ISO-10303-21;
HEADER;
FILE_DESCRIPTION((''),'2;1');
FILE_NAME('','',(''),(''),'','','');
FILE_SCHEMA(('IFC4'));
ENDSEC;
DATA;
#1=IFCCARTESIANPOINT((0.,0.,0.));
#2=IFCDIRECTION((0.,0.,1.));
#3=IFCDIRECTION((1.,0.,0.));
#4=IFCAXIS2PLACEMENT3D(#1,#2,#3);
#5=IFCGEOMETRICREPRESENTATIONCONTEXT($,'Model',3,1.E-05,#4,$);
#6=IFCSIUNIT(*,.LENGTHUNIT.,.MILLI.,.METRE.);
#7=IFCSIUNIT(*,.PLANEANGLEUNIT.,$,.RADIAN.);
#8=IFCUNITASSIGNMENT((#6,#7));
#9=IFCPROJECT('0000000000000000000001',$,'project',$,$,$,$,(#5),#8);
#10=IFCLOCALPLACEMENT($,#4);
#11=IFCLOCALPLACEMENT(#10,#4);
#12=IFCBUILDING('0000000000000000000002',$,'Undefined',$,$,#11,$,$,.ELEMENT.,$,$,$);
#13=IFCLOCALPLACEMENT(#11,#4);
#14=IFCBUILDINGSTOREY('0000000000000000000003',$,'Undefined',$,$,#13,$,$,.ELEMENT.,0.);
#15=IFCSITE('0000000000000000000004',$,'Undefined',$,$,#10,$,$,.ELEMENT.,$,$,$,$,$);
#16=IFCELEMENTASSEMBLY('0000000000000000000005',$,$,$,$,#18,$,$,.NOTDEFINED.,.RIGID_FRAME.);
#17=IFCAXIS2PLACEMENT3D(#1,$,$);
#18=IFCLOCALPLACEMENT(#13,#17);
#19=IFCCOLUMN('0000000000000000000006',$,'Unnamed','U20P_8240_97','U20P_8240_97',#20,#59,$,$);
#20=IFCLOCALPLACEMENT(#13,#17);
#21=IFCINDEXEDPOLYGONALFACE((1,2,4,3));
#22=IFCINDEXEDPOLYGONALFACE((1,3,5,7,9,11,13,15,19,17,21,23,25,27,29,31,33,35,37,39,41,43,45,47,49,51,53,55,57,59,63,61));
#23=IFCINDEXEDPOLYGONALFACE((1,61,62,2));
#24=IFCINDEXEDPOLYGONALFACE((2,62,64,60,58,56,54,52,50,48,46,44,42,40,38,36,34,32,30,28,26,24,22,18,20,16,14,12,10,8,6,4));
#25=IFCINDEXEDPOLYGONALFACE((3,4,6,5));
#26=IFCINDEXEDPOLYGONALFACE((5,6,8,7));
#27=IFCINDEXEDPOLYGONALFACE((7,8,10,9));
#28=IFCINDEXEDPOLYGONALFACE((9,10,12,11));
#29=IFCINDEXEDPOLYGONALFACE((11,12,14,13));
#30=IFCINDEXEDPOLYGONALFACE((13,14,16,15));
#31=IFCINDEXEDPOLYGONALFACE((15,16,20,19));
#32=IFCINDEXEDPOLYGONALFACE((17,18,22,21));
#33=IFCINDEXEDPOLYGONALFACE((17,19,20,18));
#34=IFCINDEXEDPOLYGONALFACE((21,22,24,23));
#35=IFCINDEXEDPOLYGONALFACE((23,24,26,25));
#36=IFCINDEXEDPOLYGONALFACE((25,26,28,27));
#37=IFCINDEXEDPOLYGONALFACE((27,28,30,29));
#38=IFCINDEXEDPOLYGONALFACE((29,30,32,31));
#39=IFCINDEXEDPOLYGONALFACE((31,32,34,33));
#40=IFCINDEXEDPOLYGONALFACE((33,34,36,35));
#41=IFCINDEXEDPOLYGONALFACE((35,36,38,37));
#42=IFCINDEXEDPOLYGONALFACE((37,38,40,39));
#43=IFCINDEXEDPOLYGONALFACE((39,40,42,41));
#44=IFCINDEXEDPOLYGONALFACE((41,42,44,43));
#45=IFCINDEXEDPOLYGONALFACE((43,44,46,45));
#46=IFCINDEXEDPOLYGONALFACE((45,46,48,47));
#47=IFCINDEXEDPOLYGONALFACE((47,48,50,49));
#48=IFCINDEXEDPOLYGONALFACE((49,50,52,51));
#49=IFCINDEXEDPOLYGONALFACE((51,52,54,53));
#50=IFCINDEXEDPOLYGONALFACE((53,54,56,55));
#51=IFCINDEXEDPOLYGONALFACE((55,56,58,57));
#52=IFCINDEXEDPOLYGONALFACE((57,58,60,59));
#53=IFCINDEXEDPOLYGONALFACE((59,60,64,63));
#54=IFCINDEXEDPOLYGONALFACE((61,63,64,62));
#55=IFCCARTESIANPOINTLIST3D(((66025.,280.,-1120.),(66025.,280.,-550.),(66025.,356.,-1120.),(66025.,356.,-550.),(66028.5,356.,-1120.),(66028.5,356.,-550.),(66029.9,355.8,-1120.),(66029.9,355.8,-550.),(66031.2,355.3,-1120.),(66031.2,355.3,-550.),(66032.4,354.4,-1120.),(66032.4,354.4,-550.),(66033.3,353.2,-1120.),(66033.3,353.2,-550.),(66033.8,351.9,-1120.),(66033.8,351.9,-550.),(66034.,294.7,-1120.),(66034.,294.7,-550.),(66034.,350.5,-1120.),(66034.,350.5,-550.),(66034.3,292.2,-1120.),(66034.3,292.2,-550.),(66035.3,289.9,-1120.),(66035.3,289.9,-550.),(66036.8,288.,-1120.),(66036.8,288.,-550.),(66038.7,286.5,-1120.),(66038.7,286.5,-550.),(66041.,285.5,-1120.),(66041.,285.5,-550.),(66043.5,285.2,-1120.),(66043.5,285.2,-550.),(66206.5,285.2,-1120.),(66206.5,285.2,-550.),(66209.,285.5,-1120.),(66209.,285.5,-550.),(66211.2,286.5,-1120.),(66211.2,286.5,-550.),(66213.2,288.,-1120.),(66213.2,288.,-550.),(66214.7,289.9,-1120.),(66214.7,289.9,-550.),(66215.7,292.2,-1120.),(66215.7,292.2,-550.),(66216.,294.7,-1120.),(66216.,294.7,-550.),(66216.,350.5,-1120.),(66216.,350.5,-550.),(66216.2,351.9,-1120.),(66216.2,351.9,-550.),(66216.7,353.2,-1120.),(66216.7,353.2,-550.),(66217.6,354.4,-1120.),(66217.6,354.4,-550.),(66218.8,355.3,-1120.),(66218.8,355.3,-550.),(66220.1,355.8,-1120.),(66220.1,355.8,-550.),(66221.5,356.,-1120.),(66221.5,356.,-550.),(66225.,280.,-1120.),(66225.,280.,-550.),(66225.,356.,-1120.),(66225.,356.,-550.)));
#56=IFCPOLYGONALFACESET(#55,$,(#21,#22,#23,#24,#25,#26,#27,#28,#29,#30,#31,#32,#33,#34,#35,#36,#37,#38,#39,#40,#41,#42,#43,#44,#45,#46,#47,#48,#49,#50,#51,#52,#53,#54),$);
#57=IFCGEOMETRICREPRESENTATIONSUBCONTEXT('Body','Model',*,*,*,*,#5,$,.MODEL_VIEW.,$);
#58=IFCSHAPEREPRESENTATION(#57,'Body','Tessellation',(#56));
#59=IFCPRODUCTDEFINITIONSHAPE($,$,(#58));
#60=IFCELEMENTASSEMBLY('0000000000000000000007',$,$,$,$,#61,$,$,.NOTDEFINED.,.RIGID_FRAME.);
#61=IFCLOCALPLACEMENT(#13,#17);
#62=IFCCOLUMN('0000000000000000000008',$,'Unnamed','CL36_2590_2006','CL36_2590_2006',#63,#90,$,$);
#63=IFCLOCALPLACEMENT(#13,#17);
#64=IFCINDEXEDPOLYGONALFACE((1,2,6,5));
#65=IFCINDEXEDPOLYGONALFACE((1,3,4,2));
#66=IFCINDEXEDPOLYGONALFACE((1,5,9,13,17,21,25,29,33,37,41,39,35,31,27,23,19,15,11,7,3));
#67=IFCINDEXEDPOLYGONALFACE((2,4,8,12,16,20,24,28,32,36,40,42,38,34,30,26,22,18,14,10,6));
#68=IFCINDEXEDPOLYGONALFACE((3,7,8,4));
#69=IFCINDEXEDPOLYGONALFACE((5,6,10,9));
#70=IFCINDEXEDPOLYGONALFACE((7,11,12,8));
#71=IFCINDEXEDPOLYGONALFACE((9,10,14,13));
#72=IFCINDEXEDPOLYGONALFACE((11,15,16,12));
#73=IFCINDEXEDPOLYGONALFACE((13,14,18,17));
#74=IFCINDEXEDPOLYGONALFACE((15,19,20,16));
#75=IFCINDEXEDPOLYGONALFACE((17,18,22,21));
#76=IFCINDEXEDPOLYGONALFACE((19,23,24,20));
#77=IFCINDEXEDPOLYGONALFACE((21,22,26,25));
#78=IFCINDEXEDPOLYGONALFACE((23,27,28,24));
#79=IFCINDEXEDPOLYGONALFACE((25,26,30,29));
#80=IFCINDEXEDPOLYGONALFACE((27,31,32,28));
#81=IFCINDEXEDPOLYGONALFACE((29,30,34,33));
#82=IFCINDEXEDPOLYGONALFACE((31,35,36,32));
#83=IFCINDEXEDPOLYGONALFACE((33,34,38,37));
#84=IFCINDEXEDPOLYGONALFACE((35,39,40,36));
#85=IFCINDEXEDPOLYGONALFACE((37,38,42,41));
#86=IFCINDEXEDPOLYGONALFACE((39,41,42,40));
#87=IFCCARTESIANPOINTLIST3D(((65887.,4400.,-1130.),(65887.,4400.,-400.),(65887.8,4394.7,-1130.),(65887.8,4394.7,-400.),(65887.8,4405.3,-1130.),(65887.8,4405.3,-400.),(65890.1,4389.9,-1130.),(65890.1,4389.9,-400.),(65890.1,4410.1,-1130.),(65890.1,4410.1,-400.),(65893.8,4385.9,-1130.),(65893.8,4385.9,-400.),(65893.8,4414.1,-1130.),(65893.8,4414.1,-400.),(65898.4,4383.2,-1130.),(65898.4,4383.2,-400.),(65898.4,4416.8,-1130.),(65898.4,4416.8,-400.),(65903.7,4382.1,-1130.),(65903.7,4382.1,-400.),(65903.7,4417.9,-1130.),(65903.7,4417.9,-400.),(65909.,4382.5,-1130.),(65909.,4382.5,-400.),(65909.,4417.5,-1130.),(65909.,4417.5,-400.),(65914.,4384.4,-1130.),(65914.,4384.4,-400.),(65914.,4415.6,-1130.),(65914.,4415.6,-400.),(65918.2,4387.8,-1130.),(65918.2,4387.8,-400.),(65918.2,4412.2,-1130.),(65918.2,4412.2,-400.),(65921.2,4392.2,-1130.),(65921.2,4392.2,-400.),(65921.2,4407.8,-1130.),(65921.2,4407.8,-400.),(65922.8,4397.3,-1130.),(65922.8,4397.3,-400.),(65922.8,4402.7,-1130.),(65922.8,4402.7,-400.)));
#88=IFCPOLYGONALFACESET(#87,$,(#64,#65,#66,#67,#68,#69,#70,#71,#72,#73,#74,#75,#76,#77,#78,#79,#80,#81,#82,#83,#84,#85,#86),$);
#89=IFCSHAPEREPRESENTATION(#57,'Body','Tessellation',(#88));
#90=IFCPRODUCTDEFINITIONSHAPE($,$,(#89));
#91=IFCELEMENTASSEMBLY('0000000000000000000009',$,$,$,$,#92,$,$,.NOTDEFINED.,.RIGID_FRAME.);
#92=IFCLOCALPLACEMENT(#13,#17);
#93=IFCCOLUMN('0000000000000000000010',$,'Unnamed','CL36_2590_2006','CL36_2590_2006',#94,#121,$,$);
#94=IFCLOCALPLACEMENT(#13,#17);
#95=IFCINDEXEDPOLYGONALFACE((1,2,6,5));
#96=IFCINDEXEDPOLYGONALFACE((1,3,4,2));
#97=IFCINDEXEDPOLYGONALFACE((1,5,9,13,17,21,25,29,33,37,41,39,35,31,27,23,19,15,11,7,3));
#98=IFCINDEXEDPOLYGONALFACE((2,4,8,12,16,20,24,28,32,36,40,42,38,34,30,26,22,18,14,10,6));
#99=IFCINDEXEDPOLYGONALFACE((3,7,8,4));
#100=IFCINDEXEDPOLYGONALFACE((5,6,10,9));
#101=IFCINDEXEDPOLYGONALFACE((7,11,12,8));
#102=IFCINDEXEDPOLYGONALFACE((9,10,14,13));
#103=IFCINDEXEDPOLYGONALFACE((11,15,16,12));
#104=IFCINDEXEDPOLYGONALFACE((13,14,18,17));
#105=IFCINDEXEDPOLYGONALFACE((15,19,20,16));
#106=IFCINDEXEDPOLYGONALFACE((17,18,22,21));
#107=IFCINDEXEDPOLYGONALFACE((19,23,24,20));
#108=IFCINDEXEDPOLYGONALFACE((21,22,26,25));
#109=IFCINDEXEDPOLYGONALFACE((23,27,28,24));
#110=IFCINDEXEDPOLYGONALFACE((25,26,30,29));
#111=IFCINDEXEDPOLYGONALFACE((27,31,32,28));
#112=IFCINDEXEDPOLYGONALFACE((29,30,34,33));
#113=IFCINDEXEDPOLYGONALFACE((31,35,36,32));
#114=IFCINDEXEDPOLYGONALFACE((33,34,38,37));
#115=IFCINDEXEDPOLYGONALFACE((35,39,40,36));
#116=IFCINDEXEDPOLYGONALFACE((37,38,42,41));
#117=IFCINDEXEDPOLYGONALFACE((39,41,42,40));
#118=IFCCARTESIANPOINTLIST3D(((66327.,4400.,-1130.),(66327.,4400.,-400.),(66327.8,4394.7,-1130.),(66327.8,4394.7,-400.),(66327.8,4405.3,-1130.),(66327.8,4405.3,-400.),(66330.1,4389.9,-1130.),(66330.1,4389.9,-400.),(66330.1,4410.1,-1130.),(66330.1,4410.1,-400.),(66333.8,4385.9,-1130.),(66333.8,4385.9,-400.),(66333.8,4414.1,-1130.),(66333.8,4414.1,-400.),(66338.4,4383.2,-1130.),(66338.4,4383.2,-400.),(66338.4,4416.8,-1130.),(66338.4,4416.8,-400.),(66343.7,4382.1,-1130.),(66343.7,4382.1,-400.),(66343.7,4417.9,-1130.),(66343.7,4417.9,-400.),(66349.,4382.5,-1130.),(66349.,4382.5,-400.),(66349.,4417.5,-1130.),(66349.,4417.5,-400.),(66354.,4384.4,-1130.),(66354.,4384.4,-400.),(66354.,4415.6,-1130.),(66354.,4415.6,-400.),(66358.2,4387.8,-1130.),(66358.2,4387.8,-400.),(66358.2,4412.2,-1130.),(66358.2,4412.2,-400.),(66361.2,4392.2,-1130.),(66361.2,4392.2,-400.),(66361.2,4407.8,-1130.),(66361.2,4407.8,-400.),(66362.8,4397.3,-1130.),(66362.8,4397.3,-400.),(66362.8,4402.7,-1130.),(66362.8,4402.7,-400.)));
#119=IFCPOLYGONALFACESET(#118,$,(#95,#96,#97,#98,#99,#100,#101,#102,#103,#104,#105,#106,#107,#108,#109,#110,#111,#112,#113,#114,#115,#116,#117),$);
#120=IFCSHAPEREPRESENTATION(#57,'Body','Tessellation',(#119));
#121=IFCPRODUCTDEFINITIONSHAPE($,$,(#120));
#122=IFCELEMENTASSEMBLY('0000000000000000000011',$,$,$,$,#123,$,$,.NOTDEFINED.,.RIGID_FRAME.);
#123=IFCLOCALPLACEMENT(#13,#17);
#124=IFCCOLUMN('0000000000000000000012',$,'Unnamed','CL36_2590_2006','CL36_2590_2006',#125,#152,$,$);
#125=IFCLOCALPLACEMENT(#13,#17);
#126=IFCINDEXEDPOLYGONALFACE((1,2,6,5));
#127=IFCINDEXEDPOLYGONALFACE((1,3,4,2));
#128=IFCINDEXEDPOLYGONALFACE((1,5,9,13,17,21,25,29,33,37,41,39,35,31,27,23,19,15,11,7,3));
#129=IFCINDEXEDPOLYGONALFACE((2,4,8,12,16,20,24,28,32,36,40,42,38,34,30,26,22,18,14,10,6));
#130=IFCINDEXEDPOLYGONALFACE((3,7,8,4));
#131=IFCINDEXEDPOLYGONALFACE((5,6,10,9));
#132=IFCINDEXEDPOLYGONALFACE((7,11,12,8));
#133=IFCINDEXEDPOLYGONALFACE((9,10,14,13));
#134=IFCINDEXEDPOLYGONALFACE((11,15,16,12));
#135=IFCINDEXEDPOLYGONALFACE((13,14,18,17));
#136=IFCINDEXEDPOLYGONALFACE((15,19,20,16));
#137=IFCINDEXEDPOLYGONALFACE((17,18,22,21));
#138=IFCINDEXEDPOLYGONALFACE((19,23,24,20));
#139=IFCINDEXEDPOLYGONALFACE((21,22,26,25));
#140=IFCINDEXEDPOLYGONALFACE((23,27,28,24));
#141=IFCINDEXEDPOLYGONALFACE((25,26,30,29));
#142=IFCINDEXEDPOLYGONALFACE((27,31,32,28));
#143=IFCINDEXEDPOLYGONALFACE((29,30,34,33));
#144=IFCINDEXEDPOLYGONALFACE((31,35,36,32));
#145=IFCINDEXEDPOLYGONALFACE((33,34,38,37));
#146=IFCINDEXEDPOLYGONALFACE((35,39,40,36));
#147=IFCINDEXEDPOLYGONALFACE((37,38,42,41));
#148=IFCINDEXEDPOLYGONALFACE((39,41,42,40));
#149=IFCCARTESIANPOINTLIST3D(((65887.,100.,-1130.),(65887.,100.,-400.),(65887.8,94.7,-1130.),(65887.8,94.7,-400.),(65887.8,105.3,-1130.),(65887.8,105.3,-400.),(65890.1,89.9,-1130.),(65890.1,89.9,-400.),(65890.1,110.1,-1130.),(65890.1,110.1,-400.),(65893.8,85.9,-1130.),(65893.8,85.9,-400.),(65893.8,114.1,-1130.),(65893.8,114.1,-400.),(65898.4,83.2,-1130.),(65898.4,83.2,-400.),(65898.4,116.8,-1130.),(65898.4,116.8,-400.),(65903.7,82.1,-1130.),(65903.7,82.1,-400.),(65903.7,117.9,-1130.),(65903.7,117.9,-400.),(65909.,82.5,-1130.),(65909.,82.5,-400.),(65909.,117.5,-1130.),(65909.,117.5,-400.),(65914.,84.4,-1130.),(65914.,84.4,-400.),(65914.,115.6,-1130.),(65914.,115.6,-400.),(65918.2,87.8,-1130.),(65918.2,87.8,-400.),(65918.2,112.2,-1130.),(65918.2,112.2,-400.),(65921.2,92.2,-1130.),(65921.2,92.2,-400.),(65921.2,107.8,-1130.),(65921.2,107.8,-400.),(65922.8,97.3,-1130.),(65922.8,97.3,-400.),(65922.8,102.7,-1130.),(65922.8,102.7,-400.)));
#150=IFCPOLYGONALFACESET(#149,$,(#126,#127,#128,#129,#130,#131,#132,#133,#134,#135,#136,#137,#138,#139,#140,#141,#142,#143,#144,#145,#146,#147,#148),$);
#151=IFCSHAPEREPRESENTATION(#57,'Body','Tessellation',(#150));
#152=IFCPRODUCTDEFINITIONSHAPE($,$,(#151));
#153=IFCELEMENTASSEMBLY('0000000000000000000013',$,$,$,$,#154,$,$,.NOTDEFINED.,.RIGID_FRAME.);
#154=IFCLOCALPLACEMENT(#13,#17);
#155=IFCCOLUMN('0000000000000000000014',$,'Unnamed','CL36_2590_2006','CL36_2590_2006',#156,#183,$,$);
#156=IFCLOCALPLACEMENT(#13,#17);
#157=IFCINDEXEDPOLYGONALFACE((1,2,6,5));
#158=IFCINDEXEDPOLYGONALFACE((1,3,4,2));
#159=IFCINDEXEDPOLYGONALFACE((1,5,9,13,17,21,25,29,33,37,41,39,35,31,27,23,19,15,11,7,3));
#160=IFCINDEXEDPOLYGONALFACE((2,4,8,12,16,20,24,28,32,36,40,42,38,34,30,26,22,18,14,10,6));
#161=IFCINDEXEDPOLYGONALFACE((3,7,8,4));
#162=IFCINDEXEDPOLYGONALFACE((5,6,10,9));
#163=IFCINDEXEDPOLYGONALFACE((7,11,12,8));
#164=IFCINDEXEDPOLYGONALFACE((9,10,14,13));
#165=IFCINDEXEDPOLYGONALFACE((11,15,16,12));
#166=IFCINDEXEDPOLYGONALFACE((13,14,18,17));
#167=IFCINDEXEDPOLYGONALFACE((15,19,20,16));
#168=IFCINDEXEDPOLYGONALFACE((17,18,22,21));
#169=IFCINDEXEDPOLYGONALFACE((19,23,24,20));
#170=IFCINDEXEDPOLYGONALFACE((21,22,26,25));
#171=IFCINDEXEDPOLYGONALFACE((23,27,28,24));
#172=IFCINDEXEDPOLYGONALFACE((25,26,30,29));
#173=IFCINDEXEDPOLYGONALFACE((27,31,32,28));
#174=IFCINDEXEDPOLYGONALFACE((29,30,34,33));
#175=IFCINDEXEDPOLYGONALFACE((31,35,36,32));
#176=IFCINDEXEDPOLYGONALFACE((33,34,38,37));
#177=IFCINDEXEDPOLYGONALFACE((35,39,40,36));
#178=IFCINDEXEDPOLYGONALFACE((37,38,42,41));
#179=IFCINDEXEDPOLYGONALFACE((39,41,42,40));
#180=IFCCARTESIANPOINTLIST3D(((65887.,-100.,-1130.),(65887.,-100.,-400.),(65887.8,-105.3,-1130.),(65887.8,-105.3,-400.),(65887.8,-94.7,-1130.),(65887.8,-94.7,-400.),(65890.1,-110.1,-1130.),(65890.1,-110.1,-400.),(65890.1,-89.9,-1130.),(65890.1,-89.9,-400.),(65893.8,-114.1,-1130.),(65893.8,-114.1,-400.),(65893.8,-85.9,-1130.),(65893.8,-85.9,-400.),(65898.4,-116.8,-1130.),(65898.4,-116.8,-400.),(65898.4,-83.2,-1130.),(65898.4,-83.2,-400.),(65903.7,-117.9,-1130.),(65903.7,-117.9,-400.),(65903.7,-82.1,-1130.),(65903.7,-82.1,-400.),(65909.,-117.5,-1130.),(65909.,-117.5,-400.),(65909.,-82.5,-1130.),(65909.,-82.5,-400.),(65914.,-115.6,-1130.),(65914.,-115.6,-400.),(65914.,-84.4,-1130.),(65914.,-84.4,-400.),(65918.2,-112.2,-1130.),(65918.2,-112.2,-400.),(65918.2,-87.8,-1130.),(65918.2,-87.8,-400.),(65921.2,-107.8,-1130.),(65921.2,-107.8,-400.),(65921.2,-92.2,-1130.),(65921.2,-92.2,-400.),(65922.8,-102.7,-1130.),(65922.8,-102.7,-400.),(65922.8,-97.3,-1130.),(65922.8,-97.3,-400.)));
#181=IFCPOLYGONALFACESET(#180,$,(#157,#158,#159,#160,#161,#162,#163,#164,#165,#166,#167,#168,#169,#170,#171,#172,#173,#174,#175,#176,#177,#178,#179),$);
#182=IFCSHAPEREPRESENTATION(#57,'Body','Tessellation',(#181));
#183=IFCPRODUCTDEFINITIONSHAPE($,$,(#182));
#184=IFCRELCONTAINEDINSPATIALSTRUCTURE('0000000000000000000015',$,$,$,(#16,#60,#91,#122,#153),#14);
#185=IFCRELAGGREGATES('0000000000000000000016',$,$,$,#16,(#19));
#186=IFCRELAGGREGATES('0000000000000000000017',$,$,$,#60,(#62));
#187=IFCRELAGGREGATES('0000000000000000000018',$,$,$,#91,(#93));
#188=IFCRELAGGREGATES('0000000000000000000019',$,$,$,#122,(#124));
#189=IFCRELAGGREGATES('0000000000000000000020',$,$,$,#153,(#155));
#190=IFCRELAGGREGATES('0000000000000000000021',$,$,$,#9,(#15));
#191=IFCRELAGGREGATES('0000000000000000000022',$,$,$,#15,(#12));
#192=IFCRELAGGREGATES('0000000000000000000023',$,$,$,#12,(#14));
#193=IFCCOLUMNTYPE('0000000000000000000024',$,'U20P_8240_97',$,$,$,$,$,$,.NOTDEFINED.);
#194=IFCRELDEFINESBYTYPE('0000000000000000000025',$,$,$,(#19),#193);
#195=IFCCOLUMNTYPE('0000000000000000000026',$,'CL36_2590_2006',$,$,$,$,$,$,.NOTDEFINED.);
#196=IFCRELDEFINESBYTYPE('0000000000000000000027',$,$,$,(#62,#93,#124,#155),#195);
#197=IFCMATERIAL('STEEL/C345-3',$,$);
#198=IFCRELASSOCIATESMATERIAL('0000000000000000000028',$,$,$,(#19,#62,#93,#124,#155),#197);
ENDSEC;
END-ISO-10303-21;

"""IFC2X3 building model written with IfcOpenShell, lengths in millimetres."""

from ifc_helpers import new_model, si_unit, frame, origin_with_axes, origin_2d_with_axis, place, context, subcontext, project, spatial, circle, u_section, extrude, material, type_object, element, aggregate, save


model = new_model("IFC2X3")

# Units and contexts
model_context = context("Model", 3, precision=1e-05, world=origin_with_axes())
body_context = subcontext(model_context, "Body", "Model", "MODEL_VIEW")
ifc_project = project(units=[si_unit("LENGTHUNIT", "METRE", prefix="MILLI"), si_unit("PLANEANGLEUNIT", "RADIAN")], contexts=[model_context])

# Site, building, storey
site_placement = place(None, origin_with_axes())
site = spatial("IfcSite", under=ifc_project, at=site_placement, Name="Undefined", CompositionType="ELEMENT")
building_placement = place(site_placement, origin_with_axes())
building = spatial("IfcBuilding", under=site, at=building_placement, Name="Undefined", CompositionType="ELEMENT")
storey_placement = place(building_placement, origin_with_axes())
storey = spatial("IfcBuildingStorey", under=building, at=storey_placement, Name="Undefined", CompositionType="ELEMENT", Elevation=0.0)

# Element assemblies, columns
ifc_material_1 = material(Name="STEEL/C345-3")
assembly_1_placement = place(storey_placement, origin_with_axes())
assembly_1 = element("IfcElementAssembly", 1, at=assembly_1_placement, inside=storey, AssemblyPlace="NOTDEFINED", PredefinedType="RIGID_FRAME")
column_type_1 = type_object("IfcColumnType", Name="U20P_8240_97", PredefinedType="NOTDEFINED")
column_1_placement = place(assembly_1_placement, frame((66125.0, 318.0, -1120.0), z_axis=(0.0, 0.0, 1.0), x_axis=(1.0, 0.0, 0.0)))
column_1 = element("IfcColumn", 2, at=column_1_placement, type_object=column_type_1, material=ifc_material_1, Name="Unnamed", Description="U20P_8240_97", ObjectType="U20P_8240_97", context=body_context, shape_type="SweptSolid", body=[
    extrude(u_section(Depth=200.0, FlangeWidth=76.0, WebThickness=5.2, FlangeThickness=9.0, FilletRadius=9.5, EdgeRadius=5.5, at=origin_2d_with_axis()), frame((0.0, 0.0, 570.0), z_axis=(0.0, 0.0, -1.0), x_axis=(0.0, 1.0, 0.0)), (0.0, 0.0, 1.0), 570.0),
])
aggregate(assembly_1, [column_1])
assembly_2_placement = place(storey_placement, origin_with_axes())
assembly_2 = element("IfcElementAssembly", 3, at=assembly_2_placement, inside=storey, AssemblyPlace="NOTDEFINED", PredefinedType="RIGID_FRAME")
column_type_2 = type_object("IfcColumnType", Name="CL36_2590_2006", PredefinedType="NOTDEFINED")
column_2_placement = place(assembly_2_placement, frame((65905.0, 4400.0, -1130.0), z_axis=(0.0, 0.0, 1.0), x_axis=(0.0, 1.0, 0.0)))
column_2 = element("IfcColumn", 4, at=column_2_placement, type_object=column_type_2, material=ifc_material_1, Name="Unnamed", Description="CL36_2590_2006", ObjectType="CL36_2590_2006", context=body_context, shape_type="SweptSolid", body=[
    extrude(circle(Radius=18.0, at=origin_2d_with_axis()), frame((0.0, 0.0, 730.0), z_axis=(0.0, 0.0, -1.0), x_axis=(0.0, 1.0, 0.0)), (0.0, 0.0, 1.0), 730.0),
])
aggregate(assembly_2, [column_2])
assembly_3_placement = place(storey_placement, origin_with_axes())
assembly_3 = element("IfcElementAssembly", 5, at=assembly_3_placement, inside=storey, AssemblyPlace="NOTDEFINED", PredefinedType="RIGID_FRAME")
column_3_placement = place(assembly_3_placement, frame((66345.0, 4400.0, -1130.0), z_axis=(0.0, 0.0, 1.0), x_axis=(0.0, 1.0, 0.0)))
column_3 = element("IfcColumn", 6, at=column_3_placement, type_object=column_type_2, material=ifc_material_1, Name="Unnamed", Description="CL36_2590_2006", ObjectType="CL36_2590_2006", context=body_context, shape_type="SweptSolid", body=[
    extrude(circle(Radius=18.0, at=origin_2d_with_axis()), frame((0.0, 0.0, 730.0), z_axis=(0.0, 0.0, -1.0), x_axis=(0.0, 1.0, 0.0)), (0.0, 0.0, 1.0), 730.0),
])
aggregate(assembly_3, [column_3])
assembly_4_placement = place(storey_placement, origin_with_axes())
assembly_4 = element("IfcElementAssembly", 7, at=assembly_4_placement, inside=storey, AssemblyPlace="NOTDEFINED", PredefinedType="RIGID_FRAME")
column_4_placement = place(assembly_4_placement, frame((65905.0, 100.0, -1130.0), z_axis=(0.0, 0.0, 1.0), x_axis=(0.0, 1.0, 0.0)))
column_4 = element("IfcColumn", 8, at=column_4_placement, type_object=column_type_2, material=ifc_material_1, Name="Unnamed", Description="CL36_2590_2006", ObjectType="CL36_2590_2006", context=body_context, shape_type="SweptSolid", body=[
    extrude(circle(Radius=18.0, at=origin_2d_with_axis()), frame((0.0, 0.0, 730.0), z_axis=(0.0, 0.0, -1.0), x_axis=(0.0, 1.0, 0.0)), (0.0, 0.0, 1.0), 730.0),
])
aggregate(assembly_4, [column_4])
assembly_5_placement = place(storey_placement, origin_with_axes())
assembly_5 = element("IfcElementAssembly", 9, at=assembly_5_placement, inside=storey, AssemblyPlace="NOTDEFINED", PredefinedType="RIGID_FRAME")
column_5_placement = place(assembly_5_placement, frame((65905.0, -100.0, -1130.0), z_axis=(0.0, 0.0, 1.0), x_axis=(0.0, 1.0, 0.0)))
column_5 = element("IfcColumn", 10, at=column_5_placement, type_object=column_type_2, material=ifc_material_1, Name="Unnamed", Description="CL36_2590_2006", ObjectType="CL36_2590_2006", context=body_context, shape_type="SweptSolid", body=[
    extrude(circle(Radius=18.0, at=origin_2d_with_axis()), frame((0.0, 0.0, 730.0), z_axis=(0.0, 0.0, -1.0), x_axis=(0.0, 1.0, 0.0)), (0.0, 0.0, 1.0), 730.0),
])
aggregate(assembly_5, [column_5])

save(model, "model.ifc")
